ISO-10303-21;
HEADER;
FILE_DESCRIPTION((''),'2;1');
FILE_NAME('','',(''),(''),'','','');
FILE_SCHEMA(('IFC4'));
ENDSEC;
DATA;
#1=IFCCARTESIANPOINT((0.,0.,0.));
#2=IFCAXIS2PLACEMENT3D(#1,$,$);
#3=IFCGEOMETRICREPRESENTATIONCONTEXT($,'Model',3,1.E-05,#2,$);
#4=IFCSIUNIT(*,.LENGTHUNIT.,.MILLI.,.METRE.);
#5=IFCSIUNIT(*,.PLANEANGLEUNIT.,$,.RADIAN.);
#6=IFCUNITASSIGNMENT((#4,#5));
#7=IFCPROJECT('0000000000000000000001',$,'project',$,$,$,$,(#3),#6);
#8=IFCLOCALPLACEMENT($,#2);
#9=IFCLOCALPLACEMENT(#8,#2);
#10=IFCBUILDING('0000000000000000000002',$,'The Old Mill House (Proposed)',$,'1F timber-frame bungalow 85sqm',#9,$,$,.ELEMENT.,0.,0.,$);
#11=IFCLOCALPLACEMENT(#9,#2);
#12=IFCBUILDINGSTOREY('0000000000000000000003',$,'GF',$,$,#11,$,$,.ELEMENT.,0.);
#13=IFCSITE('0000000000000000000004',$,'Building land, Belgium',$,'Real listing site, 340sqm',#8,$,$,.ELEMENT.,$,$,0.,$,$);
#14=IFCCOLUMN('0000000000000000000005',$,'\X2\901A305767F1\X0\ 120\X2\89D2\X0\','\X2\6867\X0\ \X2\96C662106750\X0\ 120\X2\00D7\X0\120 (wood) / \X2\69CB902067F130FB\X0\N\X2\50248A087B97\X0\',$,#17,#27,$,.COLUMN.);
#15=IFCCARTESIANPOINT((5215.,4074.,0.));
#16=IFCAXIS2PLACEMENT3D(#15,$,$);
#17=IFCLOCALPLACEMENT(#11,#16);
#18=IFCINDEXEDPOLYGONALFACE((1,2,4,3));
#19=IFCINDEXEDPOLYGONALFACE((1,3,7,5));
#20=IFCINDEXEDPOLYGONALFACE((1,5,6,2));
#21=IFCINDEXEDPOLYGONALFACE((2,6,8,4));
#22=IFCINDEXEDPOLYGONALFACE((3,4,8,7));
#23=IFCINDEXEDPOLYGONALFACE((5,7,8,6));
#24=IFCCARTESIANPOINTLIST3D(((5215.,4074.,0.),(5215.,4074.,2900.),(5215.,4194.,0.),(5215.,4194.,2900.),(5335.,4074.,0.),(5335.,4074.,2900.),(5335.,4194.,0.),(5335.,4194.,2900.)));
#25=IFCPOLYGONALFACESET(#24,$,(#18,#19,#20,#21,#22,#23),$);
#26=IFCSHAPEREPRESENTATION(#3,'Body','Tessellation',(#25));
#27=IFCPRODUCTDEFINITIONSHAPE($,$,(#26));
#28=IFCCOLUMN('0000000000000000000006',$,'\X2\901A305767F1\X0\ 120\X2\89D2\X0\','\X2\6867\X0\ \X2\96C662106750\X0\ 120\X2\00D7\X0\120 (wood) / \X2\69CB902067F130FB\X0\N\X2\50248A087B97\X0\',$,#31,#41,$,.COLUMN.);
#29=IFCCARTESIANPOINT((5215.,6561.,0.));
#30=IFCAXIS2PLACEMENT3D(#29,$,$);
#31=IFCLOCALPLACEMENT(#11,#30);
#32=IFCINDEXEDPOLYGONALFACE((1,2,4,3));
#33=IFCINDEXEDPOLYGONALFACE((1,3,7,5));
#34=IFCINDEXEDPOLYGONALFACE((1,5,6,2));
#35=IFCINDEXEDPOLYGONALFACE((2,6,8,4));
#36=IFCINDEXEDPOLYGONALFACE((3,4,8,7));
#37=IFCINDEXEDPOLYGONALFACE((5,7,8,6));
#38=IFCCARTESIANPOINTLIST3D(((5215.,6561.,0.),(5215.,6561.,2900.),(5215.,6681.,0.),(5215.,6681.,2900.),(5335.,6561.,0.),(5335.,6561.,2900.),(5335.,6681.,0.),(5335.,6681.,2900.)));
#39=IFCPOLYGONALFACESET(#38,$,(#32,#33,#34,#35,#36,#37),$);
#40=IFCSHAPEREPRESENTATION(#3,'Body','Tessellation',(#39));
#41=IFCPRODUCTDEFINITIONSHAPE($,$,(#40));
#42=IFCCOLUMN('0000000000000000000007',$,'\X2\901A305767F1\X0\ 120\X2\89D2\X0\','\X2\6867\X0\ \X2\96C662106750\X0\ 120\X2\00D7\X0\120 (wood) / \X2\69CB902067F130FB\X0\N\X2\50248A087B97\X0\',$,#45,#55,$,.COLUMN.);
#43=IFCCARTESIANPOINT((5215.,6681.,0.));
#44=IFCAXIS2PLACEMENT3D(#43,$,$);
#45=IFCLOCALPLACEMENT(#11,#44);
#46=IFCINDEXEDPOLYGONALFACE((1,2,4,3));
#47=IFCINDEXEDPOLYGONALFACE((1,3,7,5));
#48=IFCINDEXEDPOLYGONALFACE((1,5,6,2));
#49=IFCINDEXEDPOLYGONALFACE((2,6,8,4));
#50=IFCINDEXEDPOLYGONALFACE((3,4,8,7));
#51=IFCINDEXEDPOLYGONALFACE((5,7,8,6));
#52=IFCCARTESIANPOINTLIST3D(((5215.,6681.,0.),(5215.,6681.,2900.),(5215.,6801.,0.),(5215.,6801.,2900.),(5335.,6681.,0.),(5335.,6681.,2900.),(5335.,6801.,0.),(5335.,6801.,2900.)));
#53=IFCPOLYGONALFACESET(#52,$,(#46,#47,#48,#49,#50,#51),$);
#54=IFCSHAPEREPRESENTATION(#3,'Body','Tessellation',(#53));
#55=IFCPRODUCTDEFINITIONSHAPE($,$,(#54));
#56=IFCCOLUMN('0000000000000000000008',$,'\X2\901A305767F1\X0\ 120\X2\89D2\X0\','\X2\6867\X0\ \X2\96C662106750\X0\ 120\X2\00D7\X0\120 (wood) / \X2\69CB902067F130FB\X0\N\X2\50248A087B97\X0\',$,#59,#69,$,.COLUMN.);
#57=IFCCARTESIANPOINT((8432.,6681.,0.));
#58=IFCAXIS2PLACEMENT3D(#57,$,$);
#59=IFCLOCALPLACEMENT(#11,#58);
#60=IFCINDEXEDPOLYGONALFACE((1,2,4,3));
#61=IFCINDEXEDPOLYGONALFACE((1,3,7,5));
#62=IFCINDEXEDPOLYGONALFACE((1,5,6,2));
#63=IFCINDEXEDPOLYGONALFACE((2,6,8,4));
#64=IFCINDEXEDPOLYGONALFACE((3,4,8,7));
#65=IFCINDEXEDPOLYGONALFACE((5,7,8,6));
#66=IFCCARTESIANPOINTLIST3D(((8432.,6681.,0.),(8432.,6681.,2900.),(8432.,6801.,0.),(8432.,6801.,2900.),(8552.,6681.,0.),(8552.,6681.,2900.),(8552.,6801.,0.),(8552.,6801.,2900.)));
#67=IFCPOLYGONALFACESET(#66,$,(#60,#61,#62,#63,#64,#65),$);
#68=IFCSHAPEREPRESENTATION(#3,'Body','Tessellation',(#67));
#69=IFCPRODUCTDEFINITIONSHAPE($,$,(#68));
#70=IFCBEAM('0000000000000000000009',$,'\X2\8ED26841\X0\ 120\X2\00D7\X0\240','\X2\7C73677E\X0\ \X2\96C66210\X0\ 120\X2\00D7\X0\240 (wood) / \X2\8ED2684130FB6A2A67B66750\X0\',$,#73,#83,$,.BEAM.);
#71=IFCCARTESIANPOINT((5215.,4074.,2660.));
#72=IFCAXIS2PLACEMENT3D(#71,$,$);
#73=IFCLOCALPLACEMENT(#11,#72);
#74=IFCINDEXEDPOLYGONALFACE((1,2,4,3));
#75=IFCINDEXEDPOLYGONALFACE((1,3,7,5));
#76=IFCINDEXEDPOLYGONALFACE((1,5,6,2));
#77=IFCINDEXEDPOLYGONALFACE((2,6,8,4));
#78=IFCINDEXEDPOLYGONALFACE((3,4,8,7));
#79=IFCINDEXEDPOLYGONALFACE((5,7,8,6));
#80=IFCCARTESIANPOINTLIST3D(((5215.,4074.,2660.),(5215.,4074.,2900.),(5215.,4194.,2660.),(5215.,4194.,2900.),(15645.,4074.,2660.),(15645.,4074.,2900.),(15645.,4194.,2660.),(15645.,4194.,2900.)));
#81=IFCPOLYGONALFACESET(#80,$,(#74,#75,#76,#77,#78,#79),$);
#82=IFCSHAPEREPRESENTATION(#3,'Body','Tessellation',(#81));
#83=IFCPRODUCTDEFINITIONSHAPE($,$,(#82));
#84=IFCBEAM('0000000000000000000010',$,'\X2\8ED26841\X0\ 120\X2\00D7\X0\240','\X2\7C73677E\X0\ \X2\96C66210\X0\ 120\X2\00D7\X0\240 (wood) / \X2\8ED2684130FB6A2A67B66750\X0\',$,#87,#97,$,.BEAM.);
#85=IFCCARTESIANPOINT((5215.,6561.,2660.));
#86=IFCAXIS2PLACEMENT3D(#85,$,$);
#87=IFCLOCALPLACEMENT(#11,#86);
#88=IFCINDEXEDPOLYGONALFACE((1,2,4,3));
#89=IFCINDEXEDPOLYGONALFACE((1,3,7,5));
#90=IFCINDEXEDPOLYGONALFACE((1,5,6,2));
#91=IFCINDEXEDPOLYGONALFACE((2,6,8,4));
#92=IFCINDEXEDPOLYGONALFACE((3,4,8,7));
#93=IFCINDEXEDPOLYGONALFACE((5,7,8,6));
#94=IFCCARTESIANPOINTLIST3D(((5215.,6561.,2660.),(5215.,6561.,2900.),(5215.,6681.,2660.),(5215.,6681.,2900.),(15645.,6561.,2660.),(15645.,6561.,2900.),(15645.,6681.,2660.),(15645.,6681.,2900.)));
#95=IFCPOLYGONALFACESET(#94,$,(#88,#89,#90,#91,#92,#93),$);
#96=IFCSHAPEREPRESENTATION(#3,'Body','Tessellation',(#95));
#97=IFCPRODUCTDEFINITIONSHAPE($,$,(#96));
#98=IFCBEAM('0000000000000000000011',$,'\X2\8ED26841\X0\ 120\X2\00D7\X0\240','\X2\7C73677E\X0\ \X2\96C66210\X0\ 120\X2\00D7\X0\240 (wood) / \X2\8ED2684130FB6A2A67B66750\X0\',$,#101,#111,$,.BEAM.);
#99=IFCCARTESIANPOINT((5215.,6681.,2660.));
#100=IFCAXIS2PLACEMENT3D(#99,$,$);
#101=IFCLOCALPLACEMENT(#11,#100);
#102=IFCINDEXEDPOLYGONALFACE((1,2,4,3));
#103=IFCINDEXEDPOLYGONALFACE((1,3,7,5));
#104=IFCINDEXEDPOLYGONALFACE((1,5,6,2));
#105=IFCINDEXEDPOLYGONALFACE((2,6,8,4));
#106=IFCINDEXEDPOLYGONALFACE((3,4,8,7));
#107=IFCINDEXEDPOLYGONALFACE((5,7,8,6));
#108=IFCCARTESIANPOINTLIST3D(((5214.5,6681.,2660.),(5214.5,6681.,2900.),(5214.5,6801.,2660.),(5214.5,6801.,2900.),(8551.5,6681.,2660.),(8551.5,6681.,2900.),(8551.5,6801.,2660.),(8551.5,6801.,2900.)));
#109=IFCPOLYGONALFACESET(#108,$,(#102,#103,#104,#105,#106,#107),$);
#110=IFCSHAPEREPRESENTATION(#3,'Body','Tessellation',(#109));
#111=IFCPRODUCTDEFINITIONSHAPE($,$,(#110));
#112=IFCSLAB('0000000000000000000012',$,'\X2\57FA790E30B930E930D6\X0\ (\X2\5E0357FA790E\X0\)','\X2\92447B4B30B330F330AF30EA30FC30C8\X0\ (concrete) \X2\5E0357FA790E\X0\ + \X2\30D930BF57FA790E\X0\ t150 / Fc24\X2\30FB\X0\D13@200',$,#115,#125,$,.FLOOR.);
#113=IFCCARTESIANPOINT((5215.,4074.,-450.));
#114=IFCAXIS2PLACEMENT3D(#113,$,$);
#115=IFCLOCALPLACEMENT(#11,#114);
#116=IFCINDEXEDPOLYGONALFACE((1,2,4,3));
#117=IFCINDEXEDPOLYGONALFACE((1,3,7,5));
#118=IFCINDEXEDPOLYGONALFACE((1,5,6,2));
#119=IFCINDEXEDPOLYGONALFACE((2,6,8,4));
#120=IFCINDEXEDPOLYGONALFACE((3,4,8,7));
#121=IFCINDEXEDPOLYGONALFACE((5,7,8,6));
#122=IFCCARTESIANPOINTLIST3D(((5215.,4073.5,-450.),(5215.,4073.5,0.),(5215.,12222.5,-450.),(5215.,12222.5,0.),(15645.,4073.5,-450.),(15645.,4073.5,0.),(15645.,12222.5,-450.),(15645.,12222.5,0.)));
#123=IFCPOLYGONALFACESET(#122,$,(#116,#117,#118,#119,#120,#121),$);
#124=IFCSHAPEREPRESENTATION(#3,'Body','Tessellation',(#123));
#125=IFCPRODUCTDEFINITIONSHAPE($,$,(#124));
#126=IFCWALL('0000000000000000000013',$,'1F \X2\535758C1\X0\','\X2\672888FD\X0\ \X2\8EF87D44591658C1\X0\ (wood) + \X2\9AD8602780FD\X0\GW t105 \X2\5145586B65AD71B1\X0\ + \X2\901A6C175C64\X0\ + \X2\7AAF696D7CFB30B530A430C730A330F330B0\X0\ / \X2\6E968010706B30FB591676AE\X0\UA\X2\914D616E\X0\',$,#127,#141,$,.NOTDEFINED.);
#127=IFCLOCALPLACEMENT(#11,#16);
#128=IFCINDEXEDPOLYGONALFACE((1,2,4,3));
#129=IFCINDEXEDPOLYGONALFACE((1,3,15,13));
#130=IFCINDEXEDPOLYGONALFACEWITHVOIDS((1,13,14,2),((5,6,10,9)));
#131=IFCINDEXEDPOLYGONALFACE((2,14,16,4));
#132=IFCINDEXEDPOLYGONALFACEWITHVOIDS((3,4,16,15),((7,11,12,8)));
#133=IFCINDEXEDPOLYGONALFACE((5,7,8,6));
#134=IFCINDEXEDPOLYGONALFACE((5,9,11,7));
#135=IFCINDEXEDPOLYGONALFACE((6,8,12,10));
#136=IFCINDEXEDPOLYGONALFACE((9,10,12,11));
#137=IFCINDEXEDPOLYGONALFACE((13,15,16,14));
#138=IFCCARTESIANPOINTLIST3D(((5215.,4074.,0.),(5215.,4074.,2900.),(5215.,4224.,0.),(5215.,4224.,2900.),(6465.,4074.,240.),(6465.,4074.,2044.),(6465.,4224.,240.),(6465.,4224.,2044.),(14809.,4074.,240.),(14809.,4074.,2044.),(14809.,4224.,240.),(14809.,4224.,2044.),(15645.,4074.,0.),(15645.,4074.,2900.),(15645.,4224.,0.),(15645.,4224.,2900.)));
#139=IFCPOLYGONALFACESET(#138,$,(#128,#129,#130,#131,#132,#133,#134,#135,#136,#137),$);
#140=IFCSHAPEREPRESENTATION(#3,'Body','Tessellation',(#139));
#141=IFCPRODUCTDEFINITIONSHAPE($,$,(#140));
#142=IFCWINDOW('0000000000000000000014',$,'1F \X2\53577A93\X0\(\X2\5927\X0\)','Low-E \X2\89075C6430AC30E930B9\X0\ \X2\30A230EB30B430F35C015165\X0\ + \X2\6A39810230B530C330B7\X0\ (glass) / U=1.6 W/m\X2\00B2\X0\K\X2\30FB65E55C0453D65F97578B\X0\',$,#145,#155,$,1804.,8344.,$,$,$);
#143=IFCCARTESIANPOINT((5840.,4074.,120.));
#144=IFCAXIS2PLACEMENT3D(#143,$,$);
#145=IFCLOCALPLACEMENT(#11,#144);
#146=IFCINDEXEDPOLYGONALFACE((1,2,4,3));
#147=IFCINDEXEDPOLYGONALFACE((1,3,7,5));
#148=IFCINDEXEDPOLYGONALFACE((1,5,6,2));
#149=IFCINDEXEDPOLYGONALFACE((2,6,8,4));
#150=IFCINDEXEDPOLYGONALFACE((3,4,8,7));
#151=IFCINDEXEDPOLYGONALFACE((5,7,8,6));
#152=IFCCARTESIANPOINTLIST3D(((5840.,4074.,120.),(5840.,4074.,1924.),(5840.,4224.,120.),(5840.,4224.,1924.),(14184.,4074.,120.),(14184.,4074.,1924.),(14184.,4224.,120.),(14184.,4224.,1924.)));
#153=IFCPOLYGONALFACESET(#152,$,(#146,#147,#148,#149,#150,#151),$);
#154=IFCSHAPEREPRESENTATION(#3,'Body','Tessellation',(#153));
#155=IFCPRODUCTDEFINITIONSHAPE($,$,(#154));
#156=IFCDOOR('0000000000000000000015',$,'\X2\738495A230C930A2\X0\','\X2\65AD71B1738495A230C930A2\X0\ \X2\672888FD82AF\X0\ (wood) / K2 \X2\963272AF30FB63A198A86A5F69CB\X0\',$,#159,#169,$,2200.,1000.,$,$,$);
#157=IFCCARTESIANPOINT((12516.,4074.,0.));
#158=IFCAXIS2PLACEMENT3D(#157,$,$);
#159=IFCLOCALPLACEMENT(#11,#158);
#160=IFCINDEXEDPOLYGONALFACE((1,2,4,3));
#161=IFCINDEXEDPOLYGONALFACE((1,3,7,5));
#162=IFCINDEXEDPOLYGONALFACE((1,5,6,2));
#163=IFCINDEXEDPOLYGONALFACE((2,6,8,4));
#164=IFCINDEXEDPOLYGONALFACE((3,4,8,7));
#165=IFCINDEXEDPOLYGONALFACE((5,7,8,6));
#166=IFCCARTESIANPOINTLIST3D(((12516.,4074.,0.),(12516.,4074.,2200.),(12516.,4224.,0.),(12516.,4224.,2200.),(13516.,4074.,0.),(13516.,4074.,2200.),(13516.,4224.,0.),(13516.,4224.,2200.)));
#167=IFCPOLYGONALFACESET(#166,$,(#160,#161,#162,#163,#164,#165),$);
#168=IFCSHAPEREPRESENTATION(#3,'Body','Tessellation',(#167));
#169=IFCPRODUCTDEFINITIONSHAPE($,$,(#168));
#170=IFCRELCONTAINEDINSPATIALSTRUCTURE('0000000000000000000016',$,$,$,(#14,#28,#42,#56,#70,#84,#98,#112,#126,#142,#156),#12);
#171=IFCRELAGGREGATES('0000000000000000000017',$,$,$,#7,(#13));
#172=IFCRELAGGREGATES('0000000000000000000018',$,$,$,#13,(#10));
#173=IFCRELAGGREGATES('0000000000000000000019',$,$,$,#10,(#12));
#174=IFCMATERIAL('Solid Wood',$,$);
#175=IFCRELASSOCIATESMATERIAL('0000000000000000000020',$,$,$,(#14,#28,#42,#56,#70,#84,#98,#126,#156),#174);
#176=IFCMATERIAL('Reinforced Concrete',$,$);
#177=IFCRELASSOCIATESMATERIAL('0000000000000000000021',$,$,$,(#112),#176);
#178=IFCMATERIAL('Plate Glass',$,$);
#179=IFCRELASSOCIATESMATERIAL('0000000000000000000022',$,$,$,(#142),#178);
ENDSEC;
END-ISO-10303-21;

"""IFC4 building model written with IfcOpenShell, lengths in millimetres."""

from ifc_helpers import new_model, si_unit, frame, frame_2d, origin, place, context, project, spatial, rectangle, extrude, material, element, fill, save


model = new_model("IFC4")

# Units and contexts
model_context = context("Model", 3, precision=1e-05, world=origin())
ifc_project = project(units=[si_unit("LENGTHUNIT", "METRE", prefix="MILLI"), si_unit("PLANEANGLEUNIT", "RADIAN")], contexts=[model_context])

# Site, building, storey
site_placement = place(None, origin())
site = spatial("IfcSite", under=ifc_project, at=site_placement, Name="Building land, Belgium", ObjectType="Real listing site, 340sqm", CompositionType="ELEMENT", RefElevation=0.0)
building_placement = place(site_placement, origin())
building = spatial("IfcBuilding", under=site, at=building_placement, Name="The Old Mill House (Proposed)", ObjectType="1F timber-frame bungalow 85sqm", CompositionType="ELEMENT", ElevationOfRefHeight=0.0, ElevationOfTerrain=0.0)
storey_placement = place(building_placement, origin())
storey = spatial("IfcBuildingStorey", under=building, at=storey_placement, Name="GF", CompositionType="ELEMENT", Elevation=0.0)

# Columns
ifc_material_1 = material(Name="Solid Wood")
column_1_placement = place(storey_placement, frame((5215.0, 4074.0, 0.0)))
element("IfcColumn", 1, at=column_1_placement, inside=storey, material=ifc_material_1, Name="通し柱 120角", Description="桧 集成材 120×120 (wood) / 構造柱・N値計算", PredefinedType="COLUMN", context=model_context, shape_type="SweptSolid", body=[
    extrude(rectangle(XDim=120.0, YDim=120.0, at=frame_2d((60.0, 60.0))), frame((5215.0, 4074.0, 0.0)), (0.0, 0.0, 1.0), 2900.0),
])
column_2_placement = place(storey_placement, frame((5215.0, 6561.0, 0.0)))
element("IfcColumn", 2, at=column_2_placement, inside=storey, material=ifc_material_1, Name="通し柱 120角", Description="桧 集成材 120×120 (wood) / 構造柱・N値計算", PredefinedType="COLUMN", context=model_context, shape_type="SweptSolid", body=[
    extrude(rectangle(XDim=120.0, YDim=120.0, at=frame_2d((60.0, 60.0))), frame((5215.0, 6561.0, 0.0)), (0.0, 0.0, 1.0), 2900.0),
])
column_3_placement = place(storey_placement, frame((5215.0, 6681.0, 0.0)))
element("IfcColumn", 3, at=column_3_placement, inside=storey, material=ifc_material_1, Name="通し柱 120角", Description="桧 集成材 120×120 (wood) / 構造柱・N値計算", PredefinedType="COLUMN", context=model_context, shape_type="SweptSolid", body=[
    extrude(rectangle(XDim=120.0, YDim=120.0, at=frame_2d((60.0, 60.0))), frame((5215.0, 6681.0, 0.0)), (0.0, 0.0, 1.0), 2900.0),
])
column_4_placement = place(storey_placement, frame((8432.0, 6681.0, 0.0)))
element("IfcColumn", 4, at=column_4_placement, inside=storey, material=ifc_material_1, Name="通し柱 120角", Description="桧 集成材 120×120 (wood) / 構造柱・N値計算", PredefinedType="COLUMN", context=model_context, shape_type="SweptSolid", body=[
    extrude(rectangle(XDim=120.0, YDim=120.0, at=frame_2d((60.0, 60.0))), frame((8432.0, 6681.0, 0.0)), (0.0, 0.0, 1.0), 2900.0),
])

# Beams
beam_1_placement = place(storey_placement, frame((5215.0, 4074.0, 2660.0)))
element("IfcBeam", 5, at=beam_1_placement, inside=storey, material=ifc_material_1, Name="軒桁 120×240", Description="米松 集成 120×240 (wood) / 軒桁・横架材", PredefinedType="BEAM", context=model_context, shape_type="SweptSolid", body=[
    extrude(rectangle(XDim=10430.0, YDim=120.0, at=frame_2d((5215.0, 60.0))), frame((5215.0, 4074.0, 2660.0)), (0.0, 0.0, 1.0), 240.0),
])
beam_2_placement = place(storey_placement, frame((5215.0, 6561.0, 2660.0)))
element("IfcBeam", 6, at=beam_2_placement, inside=storey, material=ifc_material_1, Name="軒桁 120×240", Description="米松 集成 120×240 (wood) / 軒桁・横架材", PredefinedType="BEAM", context=model_context, shape_type="SweptSolid", body=[
    extrude(rectangle(XDim=10430.0, YDim=120.0, at=frame_2d((5215.0, 60.0))), frame((5215.0, 6561.0, 2660.0)), (0.0, 0.0, 1.0), 240.0),
])
beam_3_placement = place(storey_placement, frame((5215.0, 6681.0, 2660.0)))
element("IfcBeam", 7, at=beam_3_placement, inside=storey, material=ifc_material_1, Name="軒桁 120×240", Description="米松 集成 120×240 (wood) / 軒桁・横架材", PredefinedType="BEAM", context=model_context, shape_type="SweptSolid", body=[
    extrude(rectangle(XDim=3337.0, YDim=120.0, at=frame_2d((1668.0, 60.0))), frame((5215.0, 6681.0, 2660.0)), (0.0, 0.0, 1.0), 240.0),
])

# Slab
ifc_material_2 = material(Name="Reinforced Concrete")
slab_1_placement = place(storey_placement, frame((5215.0, 4074.0, -450.0)))
element("IfcSlab", 8, at=slab_1_placement, inside=storey, material=ifc_material_2, Name="基礎スラブ (布基礎)", Description="鉄筋コンクリート (concrete) 布基礎 + ベタ基礎 t150 / Fc24・D13@200", PredefinedType="FLOOR", context=model_context, shape_type="SweptSolid", body=[
    extrude(rectangle(XDim=10430.0, YDim=8149.0, at=frame_2d((5215.0, 4074.0))), frame((5215.0, 4074.0, -450.0)), (0.0, 0.0, 1.0), 450.0),
])

# Wall, openings, window, door
wall_1_placement = place(storey_placement, frame((5215.0, 4074.0, 0.0)))
wall_1 = element("IfcWall", 9, at=wall_1_placement, inside=storey, material=ifc_material_1, Name="1F 南壁", Description="木製 軸組外壁 (wood) + 高性能GW t105 充填断熱 + 通気層 + 窯業系サイディング / 準耐火・外皮UA配慮", PredefinedType="NOTDEFINED", context=model_context, shape_type="SweptSolid", body=[
    extrude(rectangle(XDim=10430.0, YDim=150.0, at=frame_2d((5215.0, 75.0))), frame((5215.0, 4074.0, 0.0)), (0.0, 0.0, 1.0), 2900.0),
])
opening_1_placement = place(storey_placement, frame((5840.0, 4074.0, 120.0)))
opening_1 = element("IfcOpeningElement", 10, at=opening_1_placement, cuts=wall_1, PredefinedType="NOTDEFINED", context=model_context, shape_type="SweptSolid", body=[
    extrude(rectangle(XDim=8344.0, YDim=150.0, at=frame_2d((4172.0, 75.0))), frame((5840.0, 4074.0, 120.0)), (0.0, 0.0, 1.0), 1804.0),
])
opening_2_placement = place(storey_placement, frame((12516.0, 4074.0, 0.0)))
opening_2 = element("IfcOpeningElement", 11, at=opening_2_placement, cuts=wall_1, PredefinedType="NOTDEFINED", context=model_context, shape_type="SweptSolid", body=[
    extrude(rectangle(XDim=1000.0, YDim=150.0, at=frame_2d((500.0, 75.0))), frame((12516.0, 4074.0, 0.0)), (0.0, 0.0, 1.0), 2200.0),
])
ifc_material_3 = material(Name="Plate Glass")
window_1_placement = place(storey_placement, frame((5840.0, 4074.0, 120.0)))
window_1 = element("IfcWindow", 12, at=window_1_placement, inside=storey, material=ifc_material_3, Name="1F 南窓(大)", Description="Low-E 複層ガラス アルゴン封入 + 樹脂サッシ (glass) / U=1.6 W/m²K・日射取得型", OverallHeight=1804.0, OverallWidth=8344.0, context=model_context, shape_type="SweptSolid", body=[
    extrude(rectangle(XDim=8344.0, YDim=150.0, at=frame_2d((4172.0, 75.0))), frame((5840.0, 4074.0, 120.0)), (0.0, 0.0, 1.0), 1804.0),
])
fill(opening_1, window_1)
door_placement = place(storey_placement, frame((12516.0, 4074.0, 0.0)))
door = element("IfcDoor", 13, at=door_placement, inside=storey, material=ifc_material_1, Name="玄関ドア", Description="断熱玄関ドア 木製芯 (wood) / K2 防犯・採風機構", OverallHeight=2200.0, OverallWidth=1000.0, context=model_context, shape_type="SweptSolid", body=[
    extrude(rectangle(XDim=1000.0, YDim=150.0, at=frame_2d((500.0, 75.0))), frame((12516.0, 4074.0, 0.0)), (0.0, 0.0, 1.0), 2200.0),
])
fill(opening_2, door)

save(model, "model.ifc")
